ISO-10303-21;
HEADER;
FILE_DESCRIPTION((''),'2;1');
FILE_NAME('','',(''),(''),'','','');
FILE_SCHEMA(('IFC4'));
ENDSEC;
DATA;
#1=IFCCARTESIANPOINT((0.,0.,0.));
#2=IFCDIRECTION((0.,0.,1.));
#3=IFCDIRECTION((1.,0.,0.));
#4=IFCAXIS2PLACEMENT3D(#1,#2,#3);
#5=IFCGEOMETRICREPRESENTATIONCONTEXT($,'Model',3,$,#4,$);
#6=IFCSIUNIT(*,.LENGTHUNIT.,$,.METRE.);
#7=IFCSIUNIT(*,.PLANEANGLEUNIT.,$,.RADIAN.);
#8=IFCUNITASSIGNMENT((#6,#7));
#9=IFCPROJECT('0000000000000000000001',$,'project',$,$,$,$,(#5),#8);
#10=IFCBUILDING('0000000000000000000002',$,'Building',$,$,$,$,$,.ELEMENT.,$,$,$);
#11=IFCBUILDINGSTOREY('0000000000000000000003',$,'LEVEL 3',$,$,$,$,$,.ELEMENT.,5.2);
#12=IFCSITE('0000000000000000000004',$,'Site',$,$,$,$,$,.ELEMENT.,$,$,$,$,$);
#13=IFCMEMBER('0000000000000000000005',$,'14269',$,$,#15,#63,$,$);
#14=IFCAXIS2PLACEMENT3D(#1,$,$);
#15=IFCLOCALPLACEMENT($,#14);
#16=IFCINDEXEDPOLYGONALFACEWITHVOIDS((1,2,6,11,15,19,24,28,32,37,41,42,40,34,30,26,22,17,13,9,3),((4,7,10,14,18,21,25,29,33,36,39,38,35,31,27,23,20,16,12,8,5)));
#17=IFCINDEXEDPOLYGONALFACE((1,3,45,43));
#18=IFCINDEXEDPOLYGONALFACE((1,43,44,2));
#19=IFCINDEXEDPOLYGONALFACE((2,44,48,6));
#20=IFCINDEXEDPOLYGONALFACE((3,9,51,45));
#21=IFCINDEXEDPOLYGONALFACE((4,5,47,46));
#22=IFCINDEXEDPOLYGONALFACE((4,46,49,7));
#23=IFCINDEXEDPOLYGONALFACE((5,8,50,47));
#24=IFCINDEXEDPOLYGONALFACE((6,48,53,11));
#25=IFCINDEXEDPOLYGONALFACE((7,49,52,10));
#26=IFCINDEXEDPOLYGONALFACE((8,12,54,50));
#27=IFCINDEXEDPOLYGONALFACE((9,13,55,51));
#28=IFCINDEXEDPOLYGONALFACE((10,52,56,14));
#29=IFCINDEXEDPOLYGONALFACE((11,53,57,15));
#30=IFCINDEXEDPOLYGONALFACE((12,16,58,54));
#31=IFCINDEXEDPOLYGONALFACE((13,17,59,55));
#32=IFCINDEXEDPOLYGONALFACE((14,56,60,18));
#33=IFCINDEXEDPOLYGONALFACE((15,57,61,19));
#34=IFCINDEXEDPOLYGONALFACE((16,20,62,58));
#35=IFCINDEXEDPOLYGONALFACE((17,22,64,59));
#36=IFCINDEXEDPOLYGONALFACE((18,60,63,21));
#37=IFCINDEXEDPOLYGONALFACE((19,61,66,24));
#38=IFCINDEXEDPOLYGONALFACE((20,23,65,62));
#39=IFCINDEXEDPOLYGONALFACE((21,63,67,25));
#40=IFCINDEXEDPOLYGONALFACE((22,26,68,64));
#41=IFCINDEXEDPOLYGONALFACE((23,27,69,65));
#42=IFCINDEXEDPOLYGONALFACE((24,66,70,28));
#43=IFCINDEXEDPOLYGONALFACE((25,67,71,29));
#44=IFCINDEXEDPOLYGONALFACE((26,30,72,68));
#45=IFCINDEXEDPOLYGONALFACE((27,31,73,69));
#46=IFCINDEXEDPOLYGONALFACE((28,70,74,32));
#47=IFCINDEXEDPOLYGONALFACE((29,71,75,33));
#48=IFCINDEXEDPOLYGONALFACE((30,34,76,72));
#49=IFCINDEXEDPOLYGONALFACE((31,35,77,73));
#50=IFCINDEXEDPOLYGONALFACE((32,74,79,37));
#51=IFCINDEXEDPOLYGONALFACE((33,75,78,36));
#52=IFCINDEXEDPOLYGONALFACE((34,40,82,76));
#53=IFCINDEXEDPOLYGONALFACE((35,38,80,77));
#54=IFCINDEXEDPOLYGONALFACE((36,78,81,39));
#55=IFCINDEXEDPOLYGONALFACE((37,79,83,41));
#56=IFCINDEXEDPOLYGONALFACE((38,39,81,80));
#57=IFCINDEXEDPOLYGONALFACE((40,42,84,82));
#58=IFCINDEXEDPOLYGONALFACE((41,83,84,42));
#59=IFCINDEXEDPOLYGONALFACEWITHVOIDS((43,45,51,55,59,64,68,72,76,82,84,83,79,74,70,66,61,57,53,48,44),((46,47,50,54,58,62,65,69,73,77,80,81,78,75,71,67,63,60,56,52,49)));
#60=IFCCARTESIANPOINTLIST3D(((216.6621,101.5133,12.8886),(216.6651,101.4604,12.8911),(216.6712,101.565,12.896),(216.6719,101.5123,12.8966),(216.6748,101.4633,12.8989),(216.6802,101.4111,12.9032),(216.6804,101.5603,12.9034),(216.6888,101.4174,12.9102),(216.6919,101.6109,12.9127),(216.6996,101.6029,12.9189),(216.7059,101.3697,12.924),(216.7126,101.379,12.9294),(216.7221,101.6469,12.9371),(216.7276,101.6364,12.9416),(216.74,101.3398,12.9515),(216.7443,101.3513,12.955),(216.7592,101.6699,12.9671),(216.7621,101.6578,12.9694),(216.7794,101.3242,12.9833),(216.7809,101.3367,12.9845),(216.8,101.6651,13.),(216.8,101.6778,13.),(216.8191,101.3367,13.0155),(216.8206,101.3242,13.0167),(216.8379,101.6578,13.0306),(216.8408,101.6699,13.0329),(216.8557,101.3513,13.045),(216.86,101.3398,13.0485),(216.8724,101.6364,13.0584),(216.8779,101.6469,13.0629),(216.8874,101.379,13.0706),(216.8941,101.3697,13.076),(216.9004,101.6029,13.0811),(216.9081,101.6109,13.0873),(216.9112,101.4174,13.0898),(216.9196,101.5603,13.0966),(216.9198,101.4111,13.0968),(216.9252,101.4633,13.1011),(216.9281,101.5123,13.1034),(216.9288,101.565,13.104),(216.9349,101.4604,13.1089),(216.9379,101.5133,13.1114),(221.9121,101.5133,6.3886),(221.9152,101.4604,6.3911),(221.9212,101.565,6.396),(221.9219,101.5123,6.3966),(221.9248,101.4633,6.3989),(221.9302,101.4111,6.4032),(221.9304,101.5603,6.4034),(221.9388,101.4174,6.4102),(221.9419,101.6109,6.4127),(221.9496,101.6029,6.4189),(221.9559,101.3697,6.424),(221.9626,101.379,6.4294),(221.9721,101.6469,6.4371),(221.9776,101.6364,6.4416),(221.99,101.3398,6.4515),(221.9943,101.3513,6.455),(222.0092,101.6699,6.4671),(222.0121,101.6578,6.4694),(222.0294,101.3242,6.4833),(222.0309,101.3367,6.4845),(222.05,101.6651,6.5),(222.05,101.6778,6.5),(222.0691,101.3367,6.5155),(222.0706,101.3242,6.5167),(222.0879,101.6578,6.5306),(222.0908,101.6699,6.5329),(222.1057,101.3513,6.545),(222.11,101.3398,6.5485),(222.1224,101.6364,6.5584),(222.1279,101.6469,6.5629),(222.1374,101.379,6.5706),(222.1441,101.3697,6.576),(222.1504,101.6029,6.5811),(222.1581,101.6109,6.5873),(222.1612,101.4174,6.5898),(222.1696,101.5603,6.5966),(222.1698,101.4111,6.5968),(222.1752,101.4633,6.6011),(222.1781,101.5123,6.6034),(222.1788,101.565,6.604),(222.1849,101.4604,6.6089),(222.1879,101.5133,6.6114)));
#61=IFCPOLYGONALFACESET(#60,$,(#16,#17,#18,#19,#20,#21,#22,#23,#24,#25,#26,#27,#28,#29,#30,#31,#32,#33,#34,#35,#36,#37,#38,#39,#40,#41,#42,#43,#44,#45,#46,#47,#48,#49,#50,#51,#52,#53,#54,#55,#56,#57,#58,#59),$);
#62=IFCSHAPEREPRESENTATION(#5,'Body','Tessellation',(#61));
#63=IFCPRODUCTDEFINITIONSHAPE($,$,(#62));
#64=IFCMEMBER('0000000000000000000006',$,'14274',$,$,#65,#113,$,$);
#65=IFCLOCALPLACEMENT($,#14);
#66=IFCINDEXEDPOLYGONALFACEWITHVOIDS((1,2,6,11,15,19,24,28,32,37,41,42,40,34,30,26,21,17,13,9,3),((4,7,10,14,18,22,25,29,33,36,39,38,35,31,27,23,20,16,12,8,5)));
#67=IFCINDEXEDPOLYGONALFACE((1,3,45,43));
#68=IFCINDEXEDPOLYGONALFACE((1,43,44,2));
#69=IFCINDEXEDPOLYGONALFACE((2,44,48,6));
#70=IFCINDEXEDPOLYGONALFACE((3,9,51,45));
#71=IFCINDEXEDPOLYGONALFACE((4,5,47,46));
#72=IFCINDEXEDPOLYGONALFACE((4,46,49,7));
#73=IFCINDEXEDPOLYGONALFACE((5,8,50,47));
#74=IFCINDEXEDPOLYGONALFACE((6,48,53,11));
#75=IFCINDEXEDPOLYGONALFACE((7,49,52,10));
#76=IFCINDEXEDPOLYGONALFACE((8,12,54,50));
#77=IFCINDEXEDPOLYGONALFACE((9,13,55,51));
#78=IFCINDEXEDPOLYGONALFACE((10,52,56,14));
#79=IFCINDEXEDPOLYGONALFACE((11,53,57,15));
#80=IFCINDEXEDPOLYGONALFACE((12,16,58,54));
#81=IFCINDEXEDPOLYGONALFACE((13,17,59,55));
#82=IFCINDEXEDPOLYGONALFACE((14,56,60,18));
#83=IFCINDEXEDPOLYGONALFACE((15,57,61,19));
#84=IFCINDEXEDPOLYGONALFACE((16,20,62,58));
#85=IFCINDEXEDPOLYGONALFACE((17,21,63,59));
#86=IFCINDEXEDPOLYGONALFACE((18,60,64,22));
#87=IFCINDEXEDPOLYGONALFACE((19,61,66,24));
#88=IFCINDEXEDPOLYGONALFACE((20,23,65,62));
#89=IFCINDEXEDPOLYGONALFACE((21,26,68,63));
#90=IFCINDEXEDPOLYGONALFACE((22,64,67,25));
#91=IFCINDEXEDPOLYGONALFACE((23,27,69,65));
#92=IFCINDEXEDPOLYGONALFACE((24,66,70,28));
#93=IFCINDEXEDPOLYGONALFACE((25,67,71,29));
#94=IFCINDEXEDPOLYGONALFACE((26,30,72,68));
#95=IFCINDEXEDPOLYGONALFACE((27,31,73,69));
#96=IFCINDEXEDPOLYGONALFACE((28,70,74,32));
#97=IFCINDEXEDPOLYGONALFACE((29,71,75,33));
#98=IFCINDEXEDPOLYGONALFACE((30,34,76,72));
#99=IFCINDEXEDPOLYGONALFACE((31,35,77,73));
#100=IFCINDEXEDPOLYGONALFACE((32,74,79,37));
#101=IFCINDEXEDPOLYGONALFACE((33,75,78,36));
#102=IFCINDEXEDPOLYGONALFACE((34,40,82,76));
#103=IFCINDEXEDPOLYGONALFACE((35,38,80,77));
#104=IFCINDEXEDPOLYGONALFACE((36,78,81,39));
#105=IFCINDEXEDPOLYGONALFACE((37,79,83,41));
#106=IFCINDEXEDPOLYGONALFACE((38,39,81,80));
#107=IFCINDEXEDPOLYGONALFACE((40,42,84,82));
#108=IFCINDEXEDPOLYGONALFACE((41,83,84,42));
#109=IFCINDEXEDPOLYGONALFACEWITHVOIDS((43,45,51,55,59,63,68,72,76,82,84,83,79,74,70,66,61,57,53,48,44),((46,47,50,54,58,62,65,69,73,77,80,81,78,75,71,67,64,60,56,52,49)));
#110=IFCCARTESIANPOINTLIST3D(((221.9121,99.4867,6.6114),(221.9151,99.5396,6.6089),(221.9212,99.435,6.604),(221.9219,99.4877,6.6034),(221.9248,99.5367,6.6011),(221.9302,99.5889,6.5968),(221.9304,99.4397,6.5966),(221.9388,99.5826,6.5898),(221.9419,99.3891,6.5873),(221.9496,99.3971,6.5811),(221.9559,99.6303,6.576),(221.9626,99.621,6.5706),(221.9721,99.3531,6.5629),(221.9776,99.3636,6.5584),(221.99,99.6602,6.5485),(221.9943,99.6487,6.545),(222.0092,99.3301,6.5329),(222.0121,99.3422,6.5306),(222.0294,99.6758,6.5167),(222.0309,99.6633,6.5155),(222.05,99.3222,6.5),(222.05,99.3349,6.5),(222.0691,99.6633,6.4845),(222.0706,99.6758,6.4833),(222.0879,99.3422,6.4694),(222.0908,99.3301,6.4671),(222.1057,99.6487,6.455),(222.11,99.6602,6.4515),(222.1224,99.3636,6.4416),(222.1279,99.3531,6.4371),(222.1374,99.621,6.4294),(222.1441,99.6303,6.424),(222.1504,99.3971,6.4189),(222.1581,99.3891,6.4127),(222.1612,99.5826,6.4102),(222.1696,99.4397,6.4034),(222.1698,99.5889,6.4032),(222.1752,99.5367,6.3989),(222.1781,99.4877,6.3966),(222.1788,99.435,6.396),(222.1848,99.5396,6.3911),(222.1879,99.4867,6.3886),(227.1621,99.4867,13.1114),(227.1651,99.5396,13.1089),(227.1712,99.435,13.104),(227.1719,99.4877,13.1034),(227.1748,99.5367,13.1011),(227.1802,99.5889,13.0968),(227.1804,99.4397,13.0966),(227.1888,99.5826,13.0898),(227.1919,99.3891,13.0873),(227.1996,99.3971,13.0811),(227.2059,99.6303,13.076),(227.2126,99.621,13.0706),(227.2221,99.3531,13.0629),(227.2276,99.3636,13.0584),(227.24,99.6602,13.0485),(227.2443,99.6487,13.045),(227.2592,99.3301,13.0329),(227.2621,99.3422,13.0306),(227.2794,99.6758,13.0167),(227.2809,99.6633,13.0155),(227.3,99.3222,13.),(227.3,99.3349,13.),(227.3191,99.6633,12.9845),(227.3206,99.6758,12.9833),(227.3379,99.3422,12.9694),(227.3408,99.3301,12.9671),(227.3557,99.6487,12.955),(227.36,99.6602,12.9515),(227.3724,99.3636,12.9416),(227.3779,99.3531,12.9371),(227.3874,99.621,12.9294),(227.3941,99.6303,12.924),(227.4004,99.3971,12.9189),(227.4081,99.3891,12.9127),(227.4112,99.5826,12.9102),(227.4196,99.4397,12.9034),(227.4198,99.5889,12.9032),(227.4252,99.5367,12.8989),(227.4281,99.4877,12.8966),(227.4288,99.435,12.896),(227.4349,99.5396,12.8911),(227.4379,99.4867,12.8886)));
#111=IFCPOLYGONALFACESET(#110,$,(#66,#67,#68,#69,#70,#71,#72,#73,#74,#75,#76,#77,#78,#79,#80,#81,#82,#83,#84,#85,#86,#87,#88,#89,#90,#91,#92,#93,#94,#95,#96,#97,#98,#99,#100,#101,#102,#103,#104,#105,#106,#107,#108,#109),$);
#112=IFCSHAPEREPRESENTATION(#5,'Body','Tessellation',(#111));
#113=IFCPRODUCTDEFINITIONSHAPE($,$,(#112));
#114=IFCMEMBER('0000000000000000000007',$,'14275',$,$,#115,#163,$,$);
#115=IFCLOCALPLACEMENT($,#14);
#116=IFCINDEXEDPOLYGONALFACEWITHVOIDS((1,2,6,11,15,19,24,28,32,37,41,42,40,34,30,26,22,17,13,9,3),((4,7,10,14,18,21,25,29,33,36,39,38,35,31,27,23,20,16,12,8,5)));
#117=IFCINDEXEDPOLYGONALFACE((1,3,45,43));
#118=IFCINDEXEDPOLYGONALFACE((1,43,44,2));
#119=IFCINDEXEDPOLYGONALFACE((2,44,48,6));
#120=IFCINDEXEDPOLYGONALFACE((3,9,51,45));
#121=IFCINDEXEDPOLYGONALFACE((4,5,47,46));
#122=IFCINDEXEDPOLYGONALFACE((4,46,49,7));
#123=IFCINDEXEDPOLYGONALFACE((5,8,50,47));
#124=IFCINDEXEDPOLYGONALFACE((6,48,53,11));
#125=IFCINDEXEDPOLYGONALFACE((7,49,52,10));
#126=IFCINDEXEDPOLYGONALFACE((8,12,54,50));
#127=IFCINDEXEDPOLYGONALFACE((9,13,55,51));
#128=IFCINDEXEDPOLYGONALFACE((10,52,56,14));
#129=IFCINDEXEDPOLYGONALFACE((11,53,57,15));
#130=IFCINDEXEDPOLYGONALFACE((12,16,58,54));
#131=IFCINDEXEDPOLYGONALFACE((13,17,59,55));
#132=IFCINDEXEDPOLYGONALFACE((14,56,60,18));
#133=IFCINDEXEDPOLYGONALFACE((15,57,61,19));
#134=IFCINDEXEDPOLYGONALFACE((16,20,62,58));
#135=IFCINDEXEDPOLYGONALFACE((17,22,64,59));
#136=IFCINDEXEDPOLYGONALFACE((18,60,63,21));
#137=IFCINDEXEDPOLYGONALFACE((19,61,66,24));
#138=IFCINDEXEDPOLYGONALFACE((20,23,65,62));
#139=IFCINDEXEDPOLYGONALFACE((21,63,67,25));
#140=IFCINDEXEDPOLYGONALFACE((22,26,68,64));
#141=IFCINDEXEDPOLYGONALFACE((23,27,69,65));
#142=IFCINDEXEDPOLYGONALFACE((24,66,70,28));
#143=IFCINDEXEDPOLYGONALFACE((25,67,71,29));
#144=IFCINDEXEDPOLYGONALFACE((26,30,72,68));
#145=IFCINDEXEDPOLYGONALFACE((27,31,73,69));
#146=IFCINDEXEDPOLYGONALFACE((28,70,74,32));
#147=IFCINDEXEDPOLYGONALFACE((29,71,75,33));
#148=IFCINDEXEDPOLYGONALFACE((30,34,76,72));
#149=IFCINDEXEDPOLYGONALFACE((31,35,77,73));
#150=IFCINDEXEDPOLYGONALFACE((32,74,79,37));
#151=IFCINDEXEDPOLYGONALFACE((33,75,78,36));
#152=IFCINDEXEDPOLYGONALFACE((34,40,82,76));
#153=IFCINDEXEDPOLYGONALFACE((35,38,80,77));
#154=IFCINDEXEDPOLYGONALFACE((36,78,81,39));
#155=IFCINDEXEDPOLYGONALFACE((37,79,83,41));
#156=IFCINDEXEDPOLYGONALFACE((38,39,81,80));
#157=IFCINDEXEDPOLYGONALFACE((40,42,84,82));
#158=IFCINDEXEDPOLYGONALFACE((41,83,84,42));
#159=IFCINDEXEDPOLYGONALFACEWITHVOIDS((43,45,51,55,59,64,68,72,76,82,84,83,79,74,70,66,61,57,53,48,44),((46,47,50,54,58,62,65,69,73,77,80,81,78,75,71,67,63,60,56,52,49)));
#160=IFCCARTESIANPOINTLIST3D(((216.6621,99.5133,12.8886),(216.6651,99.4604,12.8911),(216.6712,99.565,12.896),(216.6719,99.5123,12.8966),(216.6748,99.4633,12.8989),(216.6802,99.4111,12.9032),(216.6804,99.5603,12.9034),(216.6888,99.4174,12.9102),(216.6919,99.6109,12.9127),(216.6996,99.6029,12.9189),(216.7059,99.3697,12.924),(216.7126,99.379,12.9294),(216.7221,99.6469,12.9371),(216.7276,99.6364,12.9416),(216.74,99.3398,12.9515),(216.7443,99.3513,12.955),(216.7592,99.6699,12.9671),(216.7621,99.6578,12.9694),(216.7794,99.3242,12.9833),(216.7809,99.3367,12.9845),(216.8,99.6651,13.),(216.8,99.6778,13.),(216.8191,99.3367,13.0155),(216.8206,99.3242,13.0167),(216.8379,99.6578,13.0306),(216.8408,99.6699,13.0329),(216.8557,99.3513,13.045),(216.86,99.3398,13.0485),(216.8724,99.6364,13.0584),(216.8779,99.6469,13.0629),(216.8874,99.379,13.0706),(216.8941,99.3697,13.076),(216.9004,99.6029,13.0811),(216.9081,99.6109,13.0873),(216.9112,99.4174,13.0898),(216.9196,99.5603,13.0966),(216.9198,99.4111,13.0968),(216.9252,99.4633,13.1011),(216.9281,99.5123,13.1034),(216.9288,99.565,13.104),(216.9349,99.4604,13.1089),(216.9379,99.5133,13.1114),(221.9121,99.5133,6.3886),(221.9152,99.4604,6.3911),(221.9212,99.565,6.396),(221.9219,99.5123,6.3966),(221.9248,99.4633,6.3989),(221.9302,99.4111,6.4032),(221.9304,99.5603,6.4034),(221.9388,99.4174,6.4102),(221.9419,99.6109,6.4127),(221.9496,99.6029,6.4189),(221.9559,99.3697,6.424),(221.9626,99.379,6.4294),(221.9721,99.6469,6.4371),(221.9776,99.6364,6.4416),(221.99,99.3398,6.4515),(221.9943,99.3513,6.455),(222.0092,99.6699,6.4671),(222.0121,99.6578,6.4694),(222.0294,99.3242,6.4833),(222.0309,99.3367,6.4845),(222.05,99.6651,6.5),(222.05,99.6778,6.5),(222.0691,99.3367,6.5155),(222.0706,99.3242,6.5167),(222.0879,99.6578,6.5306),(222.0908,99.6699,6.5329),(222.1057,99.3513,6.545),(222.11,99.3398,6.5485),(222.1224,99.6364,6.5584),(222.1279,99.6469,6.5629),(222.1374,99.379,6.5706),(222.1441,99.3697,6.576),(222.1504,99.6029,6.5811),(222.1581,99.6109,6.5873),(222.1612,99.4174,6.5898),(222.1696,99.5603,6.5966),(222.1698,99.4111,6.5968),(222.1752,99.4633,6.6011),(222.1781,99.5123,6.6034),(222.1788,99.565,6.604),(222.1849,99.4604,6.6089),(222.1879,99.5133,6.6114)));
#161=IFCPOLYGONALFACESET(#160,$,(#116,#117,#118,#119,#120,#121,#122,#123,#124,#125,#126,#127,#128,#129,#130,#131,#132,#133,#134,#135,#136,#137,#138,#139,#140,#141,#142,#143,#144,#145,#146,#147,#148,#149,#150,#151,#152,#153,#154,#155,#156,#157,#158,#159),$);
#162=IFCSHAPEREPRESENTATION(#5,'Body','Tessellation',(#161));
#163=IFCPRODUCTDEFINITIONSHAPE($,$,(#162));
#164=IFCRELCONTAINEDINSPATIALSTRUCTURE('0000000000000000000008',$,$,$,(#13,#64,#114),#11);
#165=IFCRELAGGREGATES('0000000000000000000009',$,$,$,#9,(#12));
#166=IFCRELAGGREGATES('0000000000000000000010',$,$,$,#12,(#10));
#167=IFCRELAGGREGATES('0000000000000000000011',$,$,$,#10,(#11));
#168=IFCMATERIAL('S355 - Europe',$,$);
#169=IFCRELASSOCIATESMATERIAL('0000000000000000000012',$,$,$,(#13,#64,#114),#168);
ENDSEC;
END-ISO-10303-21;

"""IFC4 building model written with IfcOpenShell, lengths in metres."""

from ifc_helpers import new_model, si_unit, frame, origin_with_axes, origin_2d_with_axis, place, context, project, spatial, hollow_circle, extrude, material, material_profile, profile_set, profile_usage, element, save


model = new_model("IFC4")

# Units and contexts
model_context = context("Model", 3, world=origin_with_axes())
ifc_project = project(units=[si_unit("LENGTHUNIT", "METRE"), si_unit("PLANEANGLEUNIT", "RADIAN")], contexts=[model_context])

# Site, building, storey
site = spatial("IfcSite", under=ifc_project, Name="Site", CompositionType="ELEMENT")
building = spatial("IfcBuilding", under=site, Name="Building", CompositionType="ELEMENT")
storey = spatial("IfcBuildingStorey", under=building, Name="LEVEL 3", CompositionType="ELEMENT", Elevation=5.2)

# Shared definitions
ifc_material = material(Name="S355 - Europe")

# Members
ifc_material_profile_1 = material_profile(ifc_material, hollow_circle(Radius=0.1778, WallThickness=0.0127, at=origin_2d_with_axis()))
ifc_profile_set_1 = profile_set([ifc_material_profile_1])
ifc_profile_usage_1 = profile_usage(ifc_profile_set_1, cardinal=10)
member_1_placement = place(None, frame((216.8, 101.5, 13.0), z_axis=(0.628337, 0.0, -0.777941), x_axis=(0.0, 1.0, 0.0)))
element("IfcMember", 1, at=member_1_placement, inside=storey, material=ifc_profile_usage_1, Name="14269", context=model_context, shape_type="SweptSolid", body=[
    extrude(hollow_circle(Radius=0.1778, WallThickness=0.0127, at=origin_2d_with_axis()), origin_with_axes(), (0.0, 0.0, 1.0), 8.3554),
])
ifc_material_profile_2 = material_profile(ifc_material, hollow_circle(Radius=0.1778, WallThickness=0.0127, at=origin_2d_with_axis()))
ifc_profile_set_2 = profile_set([ifc_material_profile_2])
ifc_profile_usage_2 = profile_usage(ifc_profile_set_2, cardinal=10)
member_2_placement = place(None, frame((227.3, 99.5, 13.0), z_axis=(-0.628337, 0.0, -0.777941), x_axis=(0.0, -1.0, 0.0)))
element("IfcMember", 2, at=member_2_placement, inside=storey, material=ifc_profile_usage_2, Name="14274", context=model_context, shape_type="SweptSolid", body=[
    extrude(hollow_circle(Radius=0.1778, WallThickness=0.0127, at=origin_2d_with_axis()), origin_with_axes(), (0.0, 0.0, 1.0), 8.3554),
])
ifc_material_profile_3 = material_profile(ifc_material, hollow_circle(Radius=0.1778, WallThickness=0.0127, at=origin_2d_with_axis()))
ifc_profile_set_3 = profile_set([ifc_material_profile_3])
ifc_profile_usage_3 = profile_usage(ifc_profile_set_3, cardinal=10)
member_3_placement = place(None, frame((216.8, 99.5, 13.0), z_axis=(0.628337, 0.0, -0.777941), x_axis=(0.0, 1.0, 0.0)))
element("IfcMember", 3, at=member_3_placement, inside=storey, material=ifc_profile_usage_3, Name="14275", context=model_context, shape_type="SweptSolid", body=[
    extrude(hollow_circle(Radius=0.1778, WallThickness=0.0127, at=origin_2d_with_axis()), origin_with_axes(), (0.0, 0.0, 1.0), 8.3554),
])

save(model, "model.ifc")
